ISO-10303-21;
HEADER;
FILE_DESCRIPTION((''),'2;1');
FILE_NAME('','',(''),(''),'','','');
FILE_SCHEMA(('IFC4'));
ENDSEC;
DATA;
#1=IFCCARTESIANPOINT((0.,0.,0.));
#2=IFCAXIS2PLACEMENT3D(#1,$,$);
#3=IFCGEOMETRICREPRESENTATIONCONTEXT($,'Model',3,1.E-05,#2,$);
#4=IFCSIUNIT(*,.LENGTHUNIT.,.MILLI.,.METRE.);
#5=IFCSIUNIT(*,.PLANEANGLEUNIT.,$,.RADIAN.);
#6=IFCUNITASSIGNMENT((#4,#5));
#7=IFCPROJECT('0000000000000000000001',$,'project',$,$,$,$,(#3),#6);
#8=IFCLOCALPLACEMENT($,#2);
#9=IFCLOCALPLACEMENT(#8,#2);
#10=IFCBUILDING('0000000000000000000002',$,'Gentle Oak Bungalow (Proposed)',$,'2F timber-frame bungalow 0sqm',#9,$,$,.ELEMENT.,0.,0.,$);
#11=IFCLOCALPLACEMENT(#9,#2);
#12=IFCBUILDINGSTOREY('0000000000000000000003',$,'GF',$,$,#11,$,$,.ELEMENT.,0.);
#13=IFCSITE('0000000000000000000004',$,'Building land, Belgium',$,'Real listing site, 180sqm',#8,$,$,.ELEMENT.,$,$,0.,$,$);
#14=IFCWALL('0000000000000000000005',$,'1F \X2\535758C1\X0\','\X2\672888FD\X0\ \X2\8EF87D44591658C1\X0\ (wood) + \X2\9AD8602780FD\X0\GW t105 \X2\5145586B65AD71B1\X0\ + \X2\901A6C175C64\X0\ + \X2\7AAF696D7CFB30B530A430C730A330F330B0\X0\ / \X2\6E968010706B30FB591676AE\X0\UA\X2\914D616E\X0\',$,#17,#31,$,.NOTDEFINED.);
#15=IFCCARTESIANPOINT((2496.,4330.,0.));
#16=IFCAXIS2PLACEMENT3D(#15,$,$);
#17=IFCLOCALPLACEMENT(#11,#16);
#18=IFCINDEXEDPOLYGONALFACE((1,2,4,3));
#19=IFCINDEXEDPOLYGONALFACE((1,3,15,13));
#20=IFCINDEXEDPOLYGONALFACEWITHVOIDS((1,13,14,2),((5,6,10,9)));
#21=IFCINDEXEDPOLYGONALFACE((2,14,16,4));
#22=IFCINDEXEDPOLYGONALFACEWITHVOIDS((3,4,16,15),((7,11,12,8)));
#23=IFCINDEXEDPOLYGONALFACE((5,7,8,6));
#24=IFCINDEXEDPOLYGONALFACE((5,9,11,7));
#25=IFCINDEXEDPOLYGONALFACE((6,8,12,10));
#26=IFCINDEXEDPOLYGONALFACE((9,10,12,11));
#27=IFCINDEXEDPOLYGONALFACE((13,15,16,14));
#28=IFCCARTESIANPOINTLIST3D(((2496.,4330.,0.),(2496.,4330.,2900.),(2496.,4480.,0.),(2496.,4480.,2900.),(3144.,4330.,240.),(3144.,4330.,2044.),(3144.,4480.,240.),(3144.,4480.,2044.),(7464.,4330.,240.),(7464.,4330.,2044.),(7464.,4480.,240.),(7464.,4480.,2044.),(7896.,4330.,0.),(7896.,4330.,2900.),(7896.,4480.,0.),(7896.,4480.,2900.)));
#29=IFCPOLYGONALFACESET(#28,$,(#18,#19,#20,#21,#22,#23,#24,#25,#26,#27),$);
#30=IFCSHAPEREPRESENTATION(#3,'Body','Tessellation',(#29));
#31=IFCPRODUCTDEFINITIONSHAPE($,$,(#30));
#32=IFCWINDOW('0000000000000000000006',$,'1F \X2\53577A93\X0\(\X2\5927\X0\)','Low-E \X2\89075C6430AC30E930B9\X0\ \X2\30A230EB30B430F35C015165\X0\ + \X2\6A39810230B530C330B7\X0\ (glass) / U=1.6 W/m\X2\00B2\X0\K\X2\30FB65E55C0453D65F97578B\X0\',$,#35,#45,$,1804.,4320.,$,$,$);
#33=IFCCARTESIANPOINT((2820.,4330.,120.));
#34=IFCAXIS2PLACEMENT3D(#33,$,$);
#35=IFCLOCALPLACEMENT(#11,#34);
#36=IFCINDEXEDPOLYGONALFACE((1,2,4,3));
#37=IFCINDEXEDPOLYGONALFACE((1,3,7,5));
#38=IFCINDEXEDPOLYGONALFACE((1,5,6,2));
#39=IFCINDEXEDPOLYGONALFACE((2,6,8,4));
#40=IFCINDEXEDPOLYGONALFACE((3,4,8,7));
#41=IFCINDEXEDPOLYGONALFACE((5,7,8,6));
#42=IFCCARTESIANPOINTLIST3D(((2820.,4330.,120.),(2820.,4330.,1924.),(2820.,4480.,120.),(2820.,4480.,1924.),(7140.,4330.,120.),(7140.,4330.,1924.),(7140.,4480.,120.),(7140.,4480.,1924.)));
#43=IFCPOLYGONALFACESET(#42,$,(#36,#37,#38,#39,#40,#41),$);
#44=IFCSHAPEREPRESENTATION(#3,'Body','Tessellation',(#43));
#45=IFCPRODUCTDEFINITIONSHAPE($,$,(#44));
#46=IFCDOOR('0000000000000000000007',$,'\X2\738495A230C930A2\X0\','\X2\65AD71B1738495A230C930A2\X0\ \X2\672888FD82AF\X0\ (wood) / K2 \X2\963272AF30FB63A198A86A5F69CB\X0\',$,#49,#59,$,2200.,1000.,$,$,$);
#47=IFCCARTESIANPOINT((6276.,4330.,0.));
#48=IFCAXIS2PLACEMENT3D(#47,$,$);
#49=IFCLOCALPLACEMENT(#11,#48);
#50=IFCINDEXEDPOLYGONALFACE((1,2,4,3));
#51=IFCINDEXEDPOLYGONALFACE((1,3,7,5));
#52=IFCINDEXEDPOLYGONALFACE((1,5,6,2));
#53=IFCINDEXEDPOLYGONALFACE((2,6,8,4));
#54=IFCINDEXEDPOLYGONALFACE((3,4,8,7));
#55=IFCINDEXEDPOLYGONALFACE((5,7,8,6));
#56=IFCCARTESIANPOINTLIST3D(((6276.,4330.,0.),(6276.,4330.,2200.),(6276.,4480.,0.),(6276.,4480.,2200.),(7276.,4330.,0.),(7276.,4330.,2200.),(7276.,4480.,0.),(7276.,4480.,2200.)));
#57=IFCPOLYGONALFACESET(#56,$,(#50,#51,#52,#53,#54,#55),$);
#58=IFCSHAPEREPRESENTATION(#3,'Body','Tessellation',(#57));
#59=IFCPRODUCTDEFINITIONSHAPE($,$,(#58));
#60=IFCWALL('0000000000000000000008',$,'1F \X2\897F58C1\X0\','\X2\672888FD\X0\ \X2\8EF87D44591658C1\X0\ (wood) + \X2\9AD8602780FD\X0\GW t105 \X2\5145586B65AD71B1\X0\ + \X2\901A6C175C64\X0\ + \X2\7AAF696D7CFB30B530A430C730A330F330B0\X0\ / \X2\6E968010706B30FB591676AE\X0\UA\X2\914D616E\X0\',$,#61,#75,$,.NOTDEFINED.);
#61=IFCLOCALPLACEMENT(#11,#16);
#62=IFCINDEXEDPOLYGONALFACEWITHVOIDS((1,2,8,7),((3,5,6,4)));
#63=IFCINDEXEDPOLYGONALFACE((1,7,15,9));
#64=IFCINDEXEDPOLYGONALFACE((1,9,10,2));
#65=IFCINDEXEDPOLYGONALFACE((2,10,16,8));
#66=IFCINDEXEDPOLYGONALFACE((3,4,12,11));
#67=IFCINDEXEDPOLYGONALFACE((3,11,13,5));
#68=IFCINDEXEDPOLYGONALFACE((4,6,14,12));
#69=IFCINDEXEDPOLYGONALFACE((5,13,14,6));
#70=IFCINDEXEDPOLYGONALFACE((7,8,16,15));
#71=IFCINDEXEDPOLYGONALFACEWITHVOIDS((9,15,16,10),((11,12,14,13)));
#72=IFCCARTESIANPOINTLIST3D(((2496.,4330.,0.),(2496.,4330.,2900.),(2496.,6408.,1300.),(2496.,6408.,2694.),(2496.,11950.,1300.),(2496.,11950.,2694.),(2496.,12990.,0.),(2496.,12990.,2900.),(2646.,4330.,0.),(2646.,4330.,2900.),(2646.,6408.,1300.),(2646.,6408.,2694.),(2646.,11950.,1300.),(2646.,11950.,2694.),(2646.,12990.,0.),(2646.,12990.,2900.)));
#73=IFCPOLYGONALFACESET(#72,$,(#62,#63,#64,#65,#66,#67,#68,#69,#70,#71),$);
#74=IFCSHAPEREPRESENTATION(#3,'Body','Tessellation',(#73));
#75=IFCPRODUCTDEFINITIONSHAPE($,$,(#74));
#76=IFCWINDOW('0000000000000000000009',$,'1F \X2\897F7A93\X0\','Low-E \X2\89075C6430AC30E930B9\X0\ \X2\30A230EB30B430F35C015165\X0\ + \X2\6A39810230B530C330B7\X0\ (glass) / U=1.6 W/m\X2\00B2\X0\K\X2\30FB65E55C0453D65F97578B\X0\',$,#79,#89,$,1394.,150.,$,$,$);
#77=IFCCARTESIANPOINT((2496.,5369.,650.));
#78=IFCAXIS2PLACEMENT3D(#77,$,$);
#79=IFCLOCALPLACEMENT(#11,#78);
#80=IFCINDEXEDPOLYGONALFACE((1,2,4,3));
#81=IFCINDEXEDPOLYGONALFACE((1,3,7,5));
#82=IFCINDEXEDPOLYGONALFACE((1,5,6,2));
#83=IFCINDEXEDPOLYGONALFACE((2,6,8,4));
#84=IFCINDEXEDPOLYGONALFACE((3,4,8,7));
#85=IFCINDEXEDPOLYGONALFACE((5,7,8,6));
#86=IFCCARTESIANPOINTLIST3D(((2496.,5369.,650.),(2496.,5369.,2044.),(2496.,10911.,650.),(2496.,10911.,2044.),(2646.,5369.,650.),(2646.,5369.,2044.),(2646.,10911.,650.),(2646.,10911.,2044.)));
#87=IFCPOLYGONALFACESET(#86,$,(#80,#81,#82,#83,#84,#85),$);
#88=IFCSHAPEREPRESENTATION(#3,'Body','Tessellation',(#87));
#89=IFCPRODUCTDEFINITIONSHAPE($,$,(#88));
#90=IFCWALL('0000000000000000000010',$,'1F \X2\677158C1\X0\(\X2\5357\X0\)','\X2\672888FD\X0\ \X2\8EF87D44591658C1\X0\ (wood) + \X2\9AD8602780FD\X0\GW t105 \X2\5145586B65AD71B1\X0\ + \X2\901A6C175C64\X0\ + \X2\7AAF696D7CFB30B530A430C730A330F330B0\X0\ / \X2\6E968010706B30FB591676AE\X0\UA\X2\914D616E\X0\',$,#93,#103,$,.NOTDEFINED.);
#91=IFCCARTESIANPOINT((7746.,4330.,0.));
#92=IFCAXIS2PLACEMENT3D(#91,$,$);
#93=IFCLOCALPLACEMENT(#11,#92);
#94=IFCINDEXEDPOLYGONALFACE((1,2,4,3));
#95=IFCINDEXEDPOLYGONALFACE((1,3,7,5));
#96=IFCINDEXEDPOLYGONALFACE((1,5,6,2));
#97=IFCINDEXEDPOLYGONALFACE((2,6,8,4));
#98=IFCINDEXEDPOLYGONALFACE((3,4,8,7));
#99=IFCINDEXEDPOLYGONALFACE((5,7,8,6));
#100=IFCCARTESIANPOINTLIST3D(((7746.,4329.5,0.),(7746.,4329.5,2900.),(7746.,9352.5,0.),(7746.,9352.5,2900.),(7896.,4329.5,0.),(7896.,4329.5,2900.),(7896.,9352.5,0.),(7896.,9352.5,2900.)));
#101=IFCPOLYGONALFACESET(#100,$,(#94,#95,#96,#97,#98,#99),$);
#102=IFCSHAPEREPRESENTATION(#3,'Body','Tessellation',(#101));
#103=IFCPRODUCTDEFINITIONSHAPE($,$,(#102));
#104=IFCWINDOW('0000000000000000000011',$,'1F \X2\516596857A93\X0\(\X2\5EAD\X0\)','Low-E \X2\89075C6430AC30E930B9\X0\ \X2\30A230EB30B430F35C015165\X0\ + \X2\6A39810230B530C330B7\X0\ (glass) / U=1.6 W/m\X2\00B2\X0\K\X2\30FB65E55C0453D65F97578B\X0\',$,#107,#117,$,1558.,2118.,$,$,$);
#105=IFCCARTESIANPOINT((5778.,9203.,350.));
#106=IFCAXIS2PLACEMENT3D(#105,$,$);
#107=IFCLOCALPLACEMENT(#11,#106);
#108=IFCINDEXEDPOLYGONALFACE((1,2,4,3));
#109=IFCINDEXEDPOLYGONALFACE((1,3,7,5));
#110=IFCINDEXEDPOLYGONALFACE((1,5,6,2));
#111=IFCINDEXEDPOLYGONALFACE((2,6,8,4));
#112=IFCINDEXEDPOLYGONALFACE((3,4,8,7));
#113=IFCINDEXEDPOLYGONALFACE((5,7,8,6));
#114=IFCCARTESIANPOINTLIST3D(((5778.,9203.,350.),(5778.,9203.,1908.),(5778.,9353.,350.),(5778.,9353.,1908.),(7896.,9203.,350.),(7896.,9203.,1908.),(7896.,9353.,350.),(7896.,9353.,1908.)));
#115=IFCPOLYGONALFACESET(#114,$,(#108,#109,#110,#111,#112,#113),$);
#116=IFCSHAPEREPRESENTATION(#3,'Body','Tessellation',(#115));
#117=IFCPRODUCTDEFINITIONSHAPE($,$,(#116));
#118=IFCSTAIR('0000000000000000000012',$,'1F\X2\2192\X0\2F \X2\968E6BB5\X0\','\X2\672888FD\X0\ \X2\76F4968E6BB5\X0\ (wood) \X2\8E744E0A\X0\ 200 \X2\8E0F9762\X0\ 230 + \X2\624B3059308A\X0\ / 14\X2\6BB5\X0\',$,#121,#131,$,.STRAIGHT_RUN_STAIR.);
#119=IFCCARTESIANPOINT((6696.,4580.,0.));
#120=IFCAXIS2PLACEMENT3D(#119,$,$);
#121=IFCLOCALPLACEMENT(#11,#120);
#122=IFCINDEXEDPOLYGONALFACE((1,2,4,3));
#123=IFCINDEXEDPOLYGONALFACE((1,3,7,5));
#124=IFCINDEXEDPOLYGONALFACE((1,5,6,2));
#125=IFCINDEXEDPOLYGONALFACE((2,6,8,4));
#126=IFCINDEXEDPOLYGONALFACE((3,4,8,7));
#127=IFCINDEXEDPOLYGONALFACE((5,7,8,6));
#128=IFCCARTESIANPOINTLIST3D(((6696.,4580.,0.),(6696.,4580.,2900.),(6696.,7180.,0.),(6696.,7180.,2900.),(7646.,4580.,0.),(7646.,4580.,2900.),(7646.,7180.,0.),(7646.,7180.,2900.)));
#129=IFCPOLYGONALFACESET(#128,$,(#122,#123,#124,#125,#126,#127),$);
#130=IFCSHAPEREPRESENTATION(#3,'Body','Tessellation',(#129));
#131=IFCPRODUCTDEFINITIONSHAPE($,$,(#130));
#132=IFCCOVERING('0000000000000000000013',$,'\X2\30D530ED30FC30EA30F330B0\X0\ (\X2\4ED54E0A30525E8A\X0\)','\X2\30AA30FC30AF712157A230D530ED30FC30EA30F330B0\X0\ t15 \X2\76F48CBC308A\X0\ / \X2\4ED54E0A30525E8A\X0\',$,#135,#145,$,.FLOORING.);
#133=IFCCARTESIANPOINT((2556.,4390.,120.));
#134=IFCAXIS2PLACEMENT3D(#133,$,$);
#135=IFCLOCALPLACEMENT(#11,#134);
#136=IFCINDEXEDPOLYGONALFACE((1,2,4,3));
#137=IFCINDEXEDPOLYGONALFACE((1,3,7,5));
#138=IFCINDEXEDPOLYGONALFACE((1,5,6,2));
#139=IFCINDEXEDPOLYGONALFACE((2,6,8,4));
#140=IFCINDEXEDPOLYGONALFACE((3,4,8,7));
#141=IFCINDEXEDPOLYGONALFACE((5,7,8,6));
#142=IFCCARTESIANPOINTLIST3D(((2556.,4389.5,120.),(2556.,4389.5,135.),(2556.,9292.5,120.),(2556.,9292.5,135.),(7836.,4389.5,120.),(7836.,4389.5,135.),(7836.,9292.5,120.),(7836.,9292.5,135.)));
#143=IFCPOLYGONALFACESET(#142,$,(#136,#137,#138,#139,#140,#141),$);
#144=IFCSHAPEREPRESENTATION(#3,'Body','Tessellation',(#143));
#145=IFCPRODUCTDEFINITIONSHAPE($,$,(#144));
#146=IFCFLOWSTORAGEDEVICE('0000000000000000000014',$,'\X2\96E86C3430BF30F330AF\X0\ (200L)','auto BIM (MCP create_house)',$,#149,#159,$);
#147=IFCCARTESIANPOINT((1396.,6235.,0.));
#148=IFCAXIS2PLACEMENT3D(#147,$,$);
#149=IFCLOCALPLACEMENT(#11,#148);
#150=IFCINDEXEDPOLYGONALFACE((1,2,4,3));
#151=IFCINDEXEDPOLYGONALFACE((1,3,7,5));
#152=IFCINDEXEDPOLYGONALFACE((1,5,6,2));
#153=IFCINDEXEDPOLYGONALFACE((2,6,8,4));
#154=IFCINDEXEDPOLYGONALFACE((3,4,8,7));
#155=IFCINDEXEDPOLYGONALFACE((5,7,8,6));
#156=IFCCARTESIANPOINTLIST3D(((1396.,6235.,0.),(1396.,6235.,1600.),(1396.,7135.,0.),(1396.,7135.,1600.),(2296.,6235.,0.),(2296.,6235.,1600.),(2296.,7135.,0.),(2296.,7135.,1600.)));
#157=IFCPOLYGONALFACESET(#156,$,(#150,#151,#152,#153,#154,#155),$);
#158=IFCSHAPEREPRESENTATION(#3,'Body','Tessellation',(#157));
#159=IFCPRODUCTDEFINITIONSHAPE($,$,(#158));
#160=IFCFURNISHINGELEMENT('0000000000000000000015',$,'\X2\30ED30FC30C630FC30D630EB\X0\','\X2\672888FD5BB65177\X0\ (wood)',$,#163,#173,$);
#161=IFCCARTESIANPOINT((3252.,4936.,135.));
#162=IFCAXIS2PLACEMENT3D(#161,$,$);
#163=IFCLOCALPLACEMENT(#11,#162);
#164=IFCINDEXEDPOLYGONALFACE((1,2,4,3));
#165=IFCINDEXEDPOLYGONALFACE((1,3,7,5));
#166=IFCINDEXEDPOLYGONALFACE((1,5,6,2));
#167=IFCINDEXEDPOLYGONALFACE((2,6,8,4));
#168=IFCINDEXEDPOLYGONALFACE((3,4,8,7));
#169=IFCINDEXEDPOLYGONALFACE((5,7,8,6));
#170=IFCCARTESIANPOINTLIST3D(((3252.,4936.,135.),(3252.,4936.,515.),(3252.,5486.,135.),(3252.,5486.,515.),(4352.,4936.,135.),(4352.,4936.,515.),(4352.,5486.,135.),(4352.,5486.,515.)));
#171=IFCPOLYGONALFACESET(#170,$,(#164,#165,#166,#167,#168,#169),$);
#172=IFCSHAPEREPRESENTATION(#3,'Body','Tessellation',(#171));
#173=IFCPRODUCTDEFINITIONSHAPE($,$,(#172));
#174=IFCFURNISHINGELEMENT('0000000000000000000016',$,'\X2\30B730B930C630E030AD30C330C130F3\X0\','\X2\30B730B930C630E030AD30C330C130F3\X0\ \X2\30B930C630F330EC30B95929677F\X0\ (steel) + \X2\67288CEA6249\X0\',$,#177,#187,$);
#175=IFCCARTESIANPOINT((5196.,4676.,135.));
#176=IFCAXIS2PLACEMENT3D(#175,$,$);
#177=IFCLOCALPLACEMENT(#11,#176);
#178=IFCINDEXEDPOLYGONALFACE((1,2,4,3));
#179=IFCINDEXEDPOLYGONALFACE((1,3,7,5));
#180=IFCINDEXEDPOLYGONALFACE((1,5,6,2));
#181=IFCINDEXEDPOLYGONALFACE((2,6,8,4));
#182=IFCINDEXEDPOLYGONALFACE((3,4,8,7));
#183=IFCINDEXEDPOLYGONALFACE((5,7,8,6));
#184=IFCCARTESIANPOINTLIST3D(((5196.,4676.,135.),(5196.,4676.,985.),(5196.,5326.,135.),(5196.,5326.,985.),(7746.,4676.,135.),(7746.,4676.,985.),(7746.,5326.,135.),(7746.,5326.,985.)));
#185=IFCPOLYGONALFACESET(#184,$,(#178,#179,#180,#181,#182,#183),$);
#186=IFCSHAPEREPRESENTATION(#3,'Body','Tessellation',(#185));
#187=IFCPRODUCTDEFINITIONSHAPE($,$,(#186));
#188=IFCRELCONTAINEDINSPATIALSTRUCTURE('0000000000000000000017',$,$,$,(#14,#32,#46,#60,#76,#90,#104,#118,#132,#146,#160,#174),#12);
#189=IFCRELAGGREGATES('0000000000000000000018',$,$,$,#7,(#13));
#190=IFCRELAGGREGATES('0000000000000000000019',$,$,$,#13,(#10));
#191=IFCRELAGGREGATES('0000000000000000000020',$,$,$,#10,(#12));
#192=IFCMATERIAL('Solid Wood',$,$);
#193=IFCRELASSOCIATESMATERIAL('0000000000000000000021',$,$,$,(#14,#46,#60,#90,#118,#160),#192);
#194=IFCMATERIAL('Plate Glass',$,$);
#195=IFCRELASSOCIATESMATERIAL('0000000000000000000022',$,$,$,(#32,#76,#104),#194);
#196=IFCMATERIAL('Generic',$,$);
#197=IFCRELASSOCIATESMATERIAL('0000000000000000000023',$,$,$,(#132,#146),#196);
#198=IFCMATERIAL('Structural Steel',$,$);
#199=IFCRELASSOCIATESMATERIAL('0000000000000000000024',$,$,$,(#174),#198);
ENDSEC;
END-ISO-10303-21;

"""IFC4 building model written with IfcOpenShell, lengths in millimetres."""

from ifc_helpers import new_model, si_unit, frame, frame_2d, origin, place, context, project, spatial, rectangle, extrude, material, element, fill, save


model = new_model("IFC4")

# Units and contexts
model_context = context("Model", 3, precision=1e-05, world=origin())
ifc_project = project(units=[si_unit("LENGTHUNIT", "METRE", prefix="MILLI"), si_unit("PLANEANGLEUNIT", "RADIAN")], contexts=[model_context])

# Site, building, storey
site_placement = place(None, origin())
site = spatial("IfcSite", under=ifc_project, at=site_placement, Name="Building land, Belgium", ObjectType="Real listing site, 180sqm", CompositionType="ELEMENT", RefElevation=0.0)
building_placement = place(site_placement, origin())
building = spatial("IfcBuilding", under=site, at=building_placement, Name="Gentle Oak Bungalow (Proposed)", ObjectType="2F timber-frame bungalow 0sqm", CompositionType="ELEMENT", ElevationOfRefHeight=0.0, ElevationOfTerrain=0.0)
storey_placement = place(building_placement, origin())
storey = spatial("IfcBuildingStorey", under=building, at=storey_placement, Name="GF", CompositionType="ELEMENT", Elevation=0.0)

# Shared definitions
ifc_material_1 = material(Name="Solid Wood")

# Wall, openings, window, door
wall_1_placement = place(storey_placement, frame((2496.0, 4330.0, 0.0)))
wall_1 = element("IfcWall", 1, at=wall_1_placement, inside=storey, material=ifc_material_1, Name="1F 南壁", Description="木製 軸組外壁 (wood) + 高性能GW t105 充填断熱 + 通気層 + 窯業系サイディング / 準耐火・外皮UA配慮", PredefinedType="NOTDEFINED", context=model_context, shape_type="SweptSolid", body=[
    extrude(rectangle(XDim=5400.0, YDim=150.0, at=frame_2d((2700.0, 75.0))), frame((2496.0, 4330.0, 0.0)), (0.0, 0.0, 1.0), 2900.0),
])
opening_1_placement = place(storey_placement, frame((2820.0, 4330.0, 120.0)))
opening_1 = element("IfcOpeningElement", 2, at=opening_1_placement, cuts=wall_1, PredefinedType="NOTDEFINED", context=model_context, shape_type="SweptSolid", body=[
    extrude(rectangle(XDim=4320.0, YDim=150.0, at=frame_2d((2160.0, 75.0))), frame((2820.0, 4330.0, 120.0)), (0.0, 0.0, 1.0), 1804.0),
])
opening_2_placement = place(storey_placement, frame((6276.0, 4330.0, 0.0)))
opening_2 = element("IfcOpeningElement", 3, at=opening_2_placement, cuts=wall_1, PredefinedType="NOTDEFINED", context=model_context, shape_type="SweptSolid", body=[
    extrude(rectangle(XDim=1000.0, YDim=150.0, at=frame_2d((500.0, 75.0))), frame((6276.0, 4330.0, 0.0)), (0.0, 0.0, 1.0), 2200.0),
])
ifc_material_2 = material(Name="Plate Glass")
window_1_placement = place(storey_placement, frame((2820.0, 4330.0, 120.0)))
window_1 = element("IfcWindow", 4, at=window_1_placement, inside=storey, material=ifc_material_2, Name="1F 南窓(大)", Description="Low-E 複層ガラス アルゴン封入 + 樹脂サッシ (glass) / U=1.6 W/m²K・日射取得型", OverallHeight=1804.0, OverallWidth=4320.0, context=model_context, shape_type="SweptSolid", body=[
    extrude(rectangle(XDim=4320.0, YDim=150.0, at=frame_2d((2160.0, 75.0))), frame((2820.0, 4330.0, 120.0)), (0.0, 0.0, 1.0), 1804.0),
])
fill(opening_1, window_1)
door_1_placement = place(storey_placement, frame((6276.0, 4330.0, 0.0)))
door_1 = element("IfcDoor", 5, at=door_1_placement, inside=storey, material=ifc_material_1, Name="玄関ドア", Description="断熱玄関ドア 木製芯 (wood) / K2 防犯・採風機構", OverallHeight=2200.0, OverallWidth=1000.0, context=model_context, shape_type="SweptSolid", body=[
    extrude(rectangle(XDim=1000.0, YDim=150.0, at=frame_2d((500.0, 75.0))), frame((6276.0, 4330.0, 0.0)), (0.0, 0.0, 1.0), 2200.0),
])
fill(opening_2, door_1)

# Walls, openings, windows
wall_2_placement = place(storey_placement, frame((2496.0, 4330.0, 0.0)))
wall_2 = element("IfcWall", 6, at=wall_2_placement, inside=storey, material=ifc_material_1, Name="1F 西壁", Description="木製 軸組外壁 (wood) + 高性能GW t105 充填断熱 + 通気層 + 窯業系サイディング / 準耐火・外皮UA配慮", PredefinedType="NOTDEFINED", context=model_context, shape_type="SweptSolid", body=[
    extrude(rectangle(XDim=150.0, YDim=8660.0, at=frame_2d((75.0, 4330.0))), frame((2496.0, 4330.0, 0.0)), (0.0, 0.0, 1.0), 2900.0),
])
opening_3_placement = place(storey_placement, frame((2496.0, 5369.0, 650.0)))
opening_3 = element("IfcOpeningElement", 7, at=opening_3_placement, cuts=wall_2, PredefinedType="NOTDEFINED", context=model_context, shape_type="SweptSolid", body=[
    extrude(rectangle(XDim=150.0, YDim=5542.0, at=frame_2d((75.0, 2771.0))), frame((2496.0, 5369.0, 650.0)), (0.0, 0.0, 1.0), 1394.0),
])
window_2_placement = place(storey_placement, frame((2496.0, 5369.0, 650.0)))
window_2 = element("IfcWindow", 8, at=window_2_placement, inside=storey, material=ifc_material_2, Name="1F 西窓", Description="Low-E 複層ガラス アルゴン封入 + 樹脂サッシ (glass) / U=1.6 W/m²K・日射取得型", OverallHeight=1394.0, OverallWidth=150.0, context=model_context, shape_type="SweptSolid", body=[
    extrude(rectangle(XDim=150.0, YDim=5542.0, at=frame_2d((75.0, 2771.0))), frame((2496.0, 5369.0, 650.0)), (0.0, 0.0, 1.0), 1394.0),
])
fill(opening_3, window_2)
wall_3_placement = place(storey_placement, frame((7746.0, 4330.0, 0.0)))
wall_3 = element("IfcWall", 9, at=wall_3_placement, inside=storey, material=ifc_material_1, Name="1F 東壁(南)", Description="木製 軸組外壁 (wood) + 高性能GW t105 充填断熱 + 通気層 + 窯業系サイディング / 準耐火・外皮UA配慮", PredefinedType="NOTDEFINED", context=model_context, shape_type="SweptSolid", body=[
    extrude(rectangle(XDim=150.0, YDim=5023.0, at=frame_2d((75.0, 2511.0))), frame((7746.0, 4330.0, 0.0)), (0.0, 0.0, 1.0), 2900.0),
])
opening_4_placement = place(storey_placement, frame((5778.0, 9203.0, 350.0)))
opening_4 = element("IfcOpeningElement", 10, at=opening_4_placement, cuts=wall_3, PredefinedType="NOTDEFINED", context=model_context, shape_type="SweptSolid", body=[
    extrude(rectangle(XDim=2118.0, YDim=150.0, at=frame_2d((1059.0, 75.0))), frame((5778.0, 9203.0, 350.0)), (0.0, 0.0, 1.0), 1558.0),
])
window_3_placement = place(storey_placement, frame((5778.0, 9203.0, 350.0)))
window_3 = element("IfcWindow", 11, at=window_3_placement, inside=storey, material=ifc_material_2, Name="1F 入隅窓(庭)", Description="Low-E 複層ガラス アルゴン封入 + 樹脂サッシ (glass) / U=1.6 W/m²K・日射取得型", OverallHeight=1558.0, OverallWidth=2118.0, context=model_context, shape_type="SweptSolid", body=[
    extrude(rectangle(XDim=2118.0, YDim=150.0, at=frame_2d((1059.0, 75.0))), frame((5778.0, 9203.0, 350.0)), (0.0, 0.0, 1.0), 1558.0),
])
fill(opening_4, window_3)

# Stair
stair_placement = place(storey_placement, frame((6696.0, 4580.0, 0.0)))
element("IfcStair", 12, at=stair_placement, inside=storey, material=ifc_material_1, Name="1F→2F 階段", Description="木製 直階段 (wood) 蹴上 200 踏面 230 + 手すり / 14段", PredefinedType="STRAIGHT_RUN_STAIR", context=model_context, shape_type="SweptSolid", body=[
    extrude(rectangle(XDim=950.0, YDim=2600.0, at=frame_2d((475.0, 1300.0))), frame((6696.0, 4580.0, 0.0)), (0.0, 0.0, 1.0), 2900.0),
])

# Covering
ifc_material_3 = material(Name="Generic")
covering_placement = place(storey_placement, frame((2556.0, 4390.0, 120.0)))
element("IfcCovering", 13, at=covering_placement, inside=storey, material=ifc_material_3, Name="フローリング (仕上げ床)", Description="オーク無垢フローリング t15 直貼り / 仕上げ床", PredefinedType="FLOORING", context=model_context, shape_type="SweptSolid", body=[
    extrude(rectangle(XDim=5280.0, YDim=4903.0, at=frame_2d((2640.0, 2451.0))), frame((2556.0, 4390.0, 120.0)), (0.0, 0.0, 1.0), 15.0),
])

# Flow storage device
flow_storage_device_placement = place(storey_placement, frame((1396.0, 6235.0, 0.0)))
element("IfcFlowStorageDevice", 14, at=flow_storage_device_placement, inside=storey, material=ifc_material_3, Name="雨水タンク (200L)", Description="auto BIM (MCP create_house)", context=model_context, shape_type="SweptSolid", body=[
    extrude(rectangle(XDim=900.0, YDim=900.0, at=frame_2d((450.0, 450.0))), frame((1396.0, 6235.0, 0.0)), (0.0, 0.0, 1.0), 1600.0),
])

# Furnishing elements
furnishing_1_placement = place(storey_placement, frame((3252.0, 4936.0, 135.0)))
element("IfcFurnishingElement", 15, at=furnishing_1_placement, inside=storey, material=ifc_material_1, Name="ローテーブル", Description="木製家具 (wood)", context=model_context, shape_type="SweptSolid", body=[
    extrude(rectangle(XDim=1100.0, YDim=550.0, at=frame_2d((550.0, 275.0))), frame((3252.0, 4936.0, 135.0)), (0.0, 0.0, 1.0), 380.0),
])
ifc_material_4 = material(Name="Structural Steel")
furnishing_2_placement = place(storey_placement, frame((5196.0, 4676.0, 135.0)))
element("IfcFurnishingElement", 16, at=furnishing_2_placement, inside=storey, material=ifc_material_4, Name="システムキッチン", Description="システムキッチン ステンレス天板 (steel) + 木質扉", context=model_context, shape_type="SweptSolid", body=[
    extrude(rectangle(XDim=2550.0, YDim=650.0, at=frame_2d((1275.0, 325.0))), frame((5196.0, 4676.0, 135.0)), (0.0, 0.0, 1.0), 850.0),
])

save(model, "model.ifc")
